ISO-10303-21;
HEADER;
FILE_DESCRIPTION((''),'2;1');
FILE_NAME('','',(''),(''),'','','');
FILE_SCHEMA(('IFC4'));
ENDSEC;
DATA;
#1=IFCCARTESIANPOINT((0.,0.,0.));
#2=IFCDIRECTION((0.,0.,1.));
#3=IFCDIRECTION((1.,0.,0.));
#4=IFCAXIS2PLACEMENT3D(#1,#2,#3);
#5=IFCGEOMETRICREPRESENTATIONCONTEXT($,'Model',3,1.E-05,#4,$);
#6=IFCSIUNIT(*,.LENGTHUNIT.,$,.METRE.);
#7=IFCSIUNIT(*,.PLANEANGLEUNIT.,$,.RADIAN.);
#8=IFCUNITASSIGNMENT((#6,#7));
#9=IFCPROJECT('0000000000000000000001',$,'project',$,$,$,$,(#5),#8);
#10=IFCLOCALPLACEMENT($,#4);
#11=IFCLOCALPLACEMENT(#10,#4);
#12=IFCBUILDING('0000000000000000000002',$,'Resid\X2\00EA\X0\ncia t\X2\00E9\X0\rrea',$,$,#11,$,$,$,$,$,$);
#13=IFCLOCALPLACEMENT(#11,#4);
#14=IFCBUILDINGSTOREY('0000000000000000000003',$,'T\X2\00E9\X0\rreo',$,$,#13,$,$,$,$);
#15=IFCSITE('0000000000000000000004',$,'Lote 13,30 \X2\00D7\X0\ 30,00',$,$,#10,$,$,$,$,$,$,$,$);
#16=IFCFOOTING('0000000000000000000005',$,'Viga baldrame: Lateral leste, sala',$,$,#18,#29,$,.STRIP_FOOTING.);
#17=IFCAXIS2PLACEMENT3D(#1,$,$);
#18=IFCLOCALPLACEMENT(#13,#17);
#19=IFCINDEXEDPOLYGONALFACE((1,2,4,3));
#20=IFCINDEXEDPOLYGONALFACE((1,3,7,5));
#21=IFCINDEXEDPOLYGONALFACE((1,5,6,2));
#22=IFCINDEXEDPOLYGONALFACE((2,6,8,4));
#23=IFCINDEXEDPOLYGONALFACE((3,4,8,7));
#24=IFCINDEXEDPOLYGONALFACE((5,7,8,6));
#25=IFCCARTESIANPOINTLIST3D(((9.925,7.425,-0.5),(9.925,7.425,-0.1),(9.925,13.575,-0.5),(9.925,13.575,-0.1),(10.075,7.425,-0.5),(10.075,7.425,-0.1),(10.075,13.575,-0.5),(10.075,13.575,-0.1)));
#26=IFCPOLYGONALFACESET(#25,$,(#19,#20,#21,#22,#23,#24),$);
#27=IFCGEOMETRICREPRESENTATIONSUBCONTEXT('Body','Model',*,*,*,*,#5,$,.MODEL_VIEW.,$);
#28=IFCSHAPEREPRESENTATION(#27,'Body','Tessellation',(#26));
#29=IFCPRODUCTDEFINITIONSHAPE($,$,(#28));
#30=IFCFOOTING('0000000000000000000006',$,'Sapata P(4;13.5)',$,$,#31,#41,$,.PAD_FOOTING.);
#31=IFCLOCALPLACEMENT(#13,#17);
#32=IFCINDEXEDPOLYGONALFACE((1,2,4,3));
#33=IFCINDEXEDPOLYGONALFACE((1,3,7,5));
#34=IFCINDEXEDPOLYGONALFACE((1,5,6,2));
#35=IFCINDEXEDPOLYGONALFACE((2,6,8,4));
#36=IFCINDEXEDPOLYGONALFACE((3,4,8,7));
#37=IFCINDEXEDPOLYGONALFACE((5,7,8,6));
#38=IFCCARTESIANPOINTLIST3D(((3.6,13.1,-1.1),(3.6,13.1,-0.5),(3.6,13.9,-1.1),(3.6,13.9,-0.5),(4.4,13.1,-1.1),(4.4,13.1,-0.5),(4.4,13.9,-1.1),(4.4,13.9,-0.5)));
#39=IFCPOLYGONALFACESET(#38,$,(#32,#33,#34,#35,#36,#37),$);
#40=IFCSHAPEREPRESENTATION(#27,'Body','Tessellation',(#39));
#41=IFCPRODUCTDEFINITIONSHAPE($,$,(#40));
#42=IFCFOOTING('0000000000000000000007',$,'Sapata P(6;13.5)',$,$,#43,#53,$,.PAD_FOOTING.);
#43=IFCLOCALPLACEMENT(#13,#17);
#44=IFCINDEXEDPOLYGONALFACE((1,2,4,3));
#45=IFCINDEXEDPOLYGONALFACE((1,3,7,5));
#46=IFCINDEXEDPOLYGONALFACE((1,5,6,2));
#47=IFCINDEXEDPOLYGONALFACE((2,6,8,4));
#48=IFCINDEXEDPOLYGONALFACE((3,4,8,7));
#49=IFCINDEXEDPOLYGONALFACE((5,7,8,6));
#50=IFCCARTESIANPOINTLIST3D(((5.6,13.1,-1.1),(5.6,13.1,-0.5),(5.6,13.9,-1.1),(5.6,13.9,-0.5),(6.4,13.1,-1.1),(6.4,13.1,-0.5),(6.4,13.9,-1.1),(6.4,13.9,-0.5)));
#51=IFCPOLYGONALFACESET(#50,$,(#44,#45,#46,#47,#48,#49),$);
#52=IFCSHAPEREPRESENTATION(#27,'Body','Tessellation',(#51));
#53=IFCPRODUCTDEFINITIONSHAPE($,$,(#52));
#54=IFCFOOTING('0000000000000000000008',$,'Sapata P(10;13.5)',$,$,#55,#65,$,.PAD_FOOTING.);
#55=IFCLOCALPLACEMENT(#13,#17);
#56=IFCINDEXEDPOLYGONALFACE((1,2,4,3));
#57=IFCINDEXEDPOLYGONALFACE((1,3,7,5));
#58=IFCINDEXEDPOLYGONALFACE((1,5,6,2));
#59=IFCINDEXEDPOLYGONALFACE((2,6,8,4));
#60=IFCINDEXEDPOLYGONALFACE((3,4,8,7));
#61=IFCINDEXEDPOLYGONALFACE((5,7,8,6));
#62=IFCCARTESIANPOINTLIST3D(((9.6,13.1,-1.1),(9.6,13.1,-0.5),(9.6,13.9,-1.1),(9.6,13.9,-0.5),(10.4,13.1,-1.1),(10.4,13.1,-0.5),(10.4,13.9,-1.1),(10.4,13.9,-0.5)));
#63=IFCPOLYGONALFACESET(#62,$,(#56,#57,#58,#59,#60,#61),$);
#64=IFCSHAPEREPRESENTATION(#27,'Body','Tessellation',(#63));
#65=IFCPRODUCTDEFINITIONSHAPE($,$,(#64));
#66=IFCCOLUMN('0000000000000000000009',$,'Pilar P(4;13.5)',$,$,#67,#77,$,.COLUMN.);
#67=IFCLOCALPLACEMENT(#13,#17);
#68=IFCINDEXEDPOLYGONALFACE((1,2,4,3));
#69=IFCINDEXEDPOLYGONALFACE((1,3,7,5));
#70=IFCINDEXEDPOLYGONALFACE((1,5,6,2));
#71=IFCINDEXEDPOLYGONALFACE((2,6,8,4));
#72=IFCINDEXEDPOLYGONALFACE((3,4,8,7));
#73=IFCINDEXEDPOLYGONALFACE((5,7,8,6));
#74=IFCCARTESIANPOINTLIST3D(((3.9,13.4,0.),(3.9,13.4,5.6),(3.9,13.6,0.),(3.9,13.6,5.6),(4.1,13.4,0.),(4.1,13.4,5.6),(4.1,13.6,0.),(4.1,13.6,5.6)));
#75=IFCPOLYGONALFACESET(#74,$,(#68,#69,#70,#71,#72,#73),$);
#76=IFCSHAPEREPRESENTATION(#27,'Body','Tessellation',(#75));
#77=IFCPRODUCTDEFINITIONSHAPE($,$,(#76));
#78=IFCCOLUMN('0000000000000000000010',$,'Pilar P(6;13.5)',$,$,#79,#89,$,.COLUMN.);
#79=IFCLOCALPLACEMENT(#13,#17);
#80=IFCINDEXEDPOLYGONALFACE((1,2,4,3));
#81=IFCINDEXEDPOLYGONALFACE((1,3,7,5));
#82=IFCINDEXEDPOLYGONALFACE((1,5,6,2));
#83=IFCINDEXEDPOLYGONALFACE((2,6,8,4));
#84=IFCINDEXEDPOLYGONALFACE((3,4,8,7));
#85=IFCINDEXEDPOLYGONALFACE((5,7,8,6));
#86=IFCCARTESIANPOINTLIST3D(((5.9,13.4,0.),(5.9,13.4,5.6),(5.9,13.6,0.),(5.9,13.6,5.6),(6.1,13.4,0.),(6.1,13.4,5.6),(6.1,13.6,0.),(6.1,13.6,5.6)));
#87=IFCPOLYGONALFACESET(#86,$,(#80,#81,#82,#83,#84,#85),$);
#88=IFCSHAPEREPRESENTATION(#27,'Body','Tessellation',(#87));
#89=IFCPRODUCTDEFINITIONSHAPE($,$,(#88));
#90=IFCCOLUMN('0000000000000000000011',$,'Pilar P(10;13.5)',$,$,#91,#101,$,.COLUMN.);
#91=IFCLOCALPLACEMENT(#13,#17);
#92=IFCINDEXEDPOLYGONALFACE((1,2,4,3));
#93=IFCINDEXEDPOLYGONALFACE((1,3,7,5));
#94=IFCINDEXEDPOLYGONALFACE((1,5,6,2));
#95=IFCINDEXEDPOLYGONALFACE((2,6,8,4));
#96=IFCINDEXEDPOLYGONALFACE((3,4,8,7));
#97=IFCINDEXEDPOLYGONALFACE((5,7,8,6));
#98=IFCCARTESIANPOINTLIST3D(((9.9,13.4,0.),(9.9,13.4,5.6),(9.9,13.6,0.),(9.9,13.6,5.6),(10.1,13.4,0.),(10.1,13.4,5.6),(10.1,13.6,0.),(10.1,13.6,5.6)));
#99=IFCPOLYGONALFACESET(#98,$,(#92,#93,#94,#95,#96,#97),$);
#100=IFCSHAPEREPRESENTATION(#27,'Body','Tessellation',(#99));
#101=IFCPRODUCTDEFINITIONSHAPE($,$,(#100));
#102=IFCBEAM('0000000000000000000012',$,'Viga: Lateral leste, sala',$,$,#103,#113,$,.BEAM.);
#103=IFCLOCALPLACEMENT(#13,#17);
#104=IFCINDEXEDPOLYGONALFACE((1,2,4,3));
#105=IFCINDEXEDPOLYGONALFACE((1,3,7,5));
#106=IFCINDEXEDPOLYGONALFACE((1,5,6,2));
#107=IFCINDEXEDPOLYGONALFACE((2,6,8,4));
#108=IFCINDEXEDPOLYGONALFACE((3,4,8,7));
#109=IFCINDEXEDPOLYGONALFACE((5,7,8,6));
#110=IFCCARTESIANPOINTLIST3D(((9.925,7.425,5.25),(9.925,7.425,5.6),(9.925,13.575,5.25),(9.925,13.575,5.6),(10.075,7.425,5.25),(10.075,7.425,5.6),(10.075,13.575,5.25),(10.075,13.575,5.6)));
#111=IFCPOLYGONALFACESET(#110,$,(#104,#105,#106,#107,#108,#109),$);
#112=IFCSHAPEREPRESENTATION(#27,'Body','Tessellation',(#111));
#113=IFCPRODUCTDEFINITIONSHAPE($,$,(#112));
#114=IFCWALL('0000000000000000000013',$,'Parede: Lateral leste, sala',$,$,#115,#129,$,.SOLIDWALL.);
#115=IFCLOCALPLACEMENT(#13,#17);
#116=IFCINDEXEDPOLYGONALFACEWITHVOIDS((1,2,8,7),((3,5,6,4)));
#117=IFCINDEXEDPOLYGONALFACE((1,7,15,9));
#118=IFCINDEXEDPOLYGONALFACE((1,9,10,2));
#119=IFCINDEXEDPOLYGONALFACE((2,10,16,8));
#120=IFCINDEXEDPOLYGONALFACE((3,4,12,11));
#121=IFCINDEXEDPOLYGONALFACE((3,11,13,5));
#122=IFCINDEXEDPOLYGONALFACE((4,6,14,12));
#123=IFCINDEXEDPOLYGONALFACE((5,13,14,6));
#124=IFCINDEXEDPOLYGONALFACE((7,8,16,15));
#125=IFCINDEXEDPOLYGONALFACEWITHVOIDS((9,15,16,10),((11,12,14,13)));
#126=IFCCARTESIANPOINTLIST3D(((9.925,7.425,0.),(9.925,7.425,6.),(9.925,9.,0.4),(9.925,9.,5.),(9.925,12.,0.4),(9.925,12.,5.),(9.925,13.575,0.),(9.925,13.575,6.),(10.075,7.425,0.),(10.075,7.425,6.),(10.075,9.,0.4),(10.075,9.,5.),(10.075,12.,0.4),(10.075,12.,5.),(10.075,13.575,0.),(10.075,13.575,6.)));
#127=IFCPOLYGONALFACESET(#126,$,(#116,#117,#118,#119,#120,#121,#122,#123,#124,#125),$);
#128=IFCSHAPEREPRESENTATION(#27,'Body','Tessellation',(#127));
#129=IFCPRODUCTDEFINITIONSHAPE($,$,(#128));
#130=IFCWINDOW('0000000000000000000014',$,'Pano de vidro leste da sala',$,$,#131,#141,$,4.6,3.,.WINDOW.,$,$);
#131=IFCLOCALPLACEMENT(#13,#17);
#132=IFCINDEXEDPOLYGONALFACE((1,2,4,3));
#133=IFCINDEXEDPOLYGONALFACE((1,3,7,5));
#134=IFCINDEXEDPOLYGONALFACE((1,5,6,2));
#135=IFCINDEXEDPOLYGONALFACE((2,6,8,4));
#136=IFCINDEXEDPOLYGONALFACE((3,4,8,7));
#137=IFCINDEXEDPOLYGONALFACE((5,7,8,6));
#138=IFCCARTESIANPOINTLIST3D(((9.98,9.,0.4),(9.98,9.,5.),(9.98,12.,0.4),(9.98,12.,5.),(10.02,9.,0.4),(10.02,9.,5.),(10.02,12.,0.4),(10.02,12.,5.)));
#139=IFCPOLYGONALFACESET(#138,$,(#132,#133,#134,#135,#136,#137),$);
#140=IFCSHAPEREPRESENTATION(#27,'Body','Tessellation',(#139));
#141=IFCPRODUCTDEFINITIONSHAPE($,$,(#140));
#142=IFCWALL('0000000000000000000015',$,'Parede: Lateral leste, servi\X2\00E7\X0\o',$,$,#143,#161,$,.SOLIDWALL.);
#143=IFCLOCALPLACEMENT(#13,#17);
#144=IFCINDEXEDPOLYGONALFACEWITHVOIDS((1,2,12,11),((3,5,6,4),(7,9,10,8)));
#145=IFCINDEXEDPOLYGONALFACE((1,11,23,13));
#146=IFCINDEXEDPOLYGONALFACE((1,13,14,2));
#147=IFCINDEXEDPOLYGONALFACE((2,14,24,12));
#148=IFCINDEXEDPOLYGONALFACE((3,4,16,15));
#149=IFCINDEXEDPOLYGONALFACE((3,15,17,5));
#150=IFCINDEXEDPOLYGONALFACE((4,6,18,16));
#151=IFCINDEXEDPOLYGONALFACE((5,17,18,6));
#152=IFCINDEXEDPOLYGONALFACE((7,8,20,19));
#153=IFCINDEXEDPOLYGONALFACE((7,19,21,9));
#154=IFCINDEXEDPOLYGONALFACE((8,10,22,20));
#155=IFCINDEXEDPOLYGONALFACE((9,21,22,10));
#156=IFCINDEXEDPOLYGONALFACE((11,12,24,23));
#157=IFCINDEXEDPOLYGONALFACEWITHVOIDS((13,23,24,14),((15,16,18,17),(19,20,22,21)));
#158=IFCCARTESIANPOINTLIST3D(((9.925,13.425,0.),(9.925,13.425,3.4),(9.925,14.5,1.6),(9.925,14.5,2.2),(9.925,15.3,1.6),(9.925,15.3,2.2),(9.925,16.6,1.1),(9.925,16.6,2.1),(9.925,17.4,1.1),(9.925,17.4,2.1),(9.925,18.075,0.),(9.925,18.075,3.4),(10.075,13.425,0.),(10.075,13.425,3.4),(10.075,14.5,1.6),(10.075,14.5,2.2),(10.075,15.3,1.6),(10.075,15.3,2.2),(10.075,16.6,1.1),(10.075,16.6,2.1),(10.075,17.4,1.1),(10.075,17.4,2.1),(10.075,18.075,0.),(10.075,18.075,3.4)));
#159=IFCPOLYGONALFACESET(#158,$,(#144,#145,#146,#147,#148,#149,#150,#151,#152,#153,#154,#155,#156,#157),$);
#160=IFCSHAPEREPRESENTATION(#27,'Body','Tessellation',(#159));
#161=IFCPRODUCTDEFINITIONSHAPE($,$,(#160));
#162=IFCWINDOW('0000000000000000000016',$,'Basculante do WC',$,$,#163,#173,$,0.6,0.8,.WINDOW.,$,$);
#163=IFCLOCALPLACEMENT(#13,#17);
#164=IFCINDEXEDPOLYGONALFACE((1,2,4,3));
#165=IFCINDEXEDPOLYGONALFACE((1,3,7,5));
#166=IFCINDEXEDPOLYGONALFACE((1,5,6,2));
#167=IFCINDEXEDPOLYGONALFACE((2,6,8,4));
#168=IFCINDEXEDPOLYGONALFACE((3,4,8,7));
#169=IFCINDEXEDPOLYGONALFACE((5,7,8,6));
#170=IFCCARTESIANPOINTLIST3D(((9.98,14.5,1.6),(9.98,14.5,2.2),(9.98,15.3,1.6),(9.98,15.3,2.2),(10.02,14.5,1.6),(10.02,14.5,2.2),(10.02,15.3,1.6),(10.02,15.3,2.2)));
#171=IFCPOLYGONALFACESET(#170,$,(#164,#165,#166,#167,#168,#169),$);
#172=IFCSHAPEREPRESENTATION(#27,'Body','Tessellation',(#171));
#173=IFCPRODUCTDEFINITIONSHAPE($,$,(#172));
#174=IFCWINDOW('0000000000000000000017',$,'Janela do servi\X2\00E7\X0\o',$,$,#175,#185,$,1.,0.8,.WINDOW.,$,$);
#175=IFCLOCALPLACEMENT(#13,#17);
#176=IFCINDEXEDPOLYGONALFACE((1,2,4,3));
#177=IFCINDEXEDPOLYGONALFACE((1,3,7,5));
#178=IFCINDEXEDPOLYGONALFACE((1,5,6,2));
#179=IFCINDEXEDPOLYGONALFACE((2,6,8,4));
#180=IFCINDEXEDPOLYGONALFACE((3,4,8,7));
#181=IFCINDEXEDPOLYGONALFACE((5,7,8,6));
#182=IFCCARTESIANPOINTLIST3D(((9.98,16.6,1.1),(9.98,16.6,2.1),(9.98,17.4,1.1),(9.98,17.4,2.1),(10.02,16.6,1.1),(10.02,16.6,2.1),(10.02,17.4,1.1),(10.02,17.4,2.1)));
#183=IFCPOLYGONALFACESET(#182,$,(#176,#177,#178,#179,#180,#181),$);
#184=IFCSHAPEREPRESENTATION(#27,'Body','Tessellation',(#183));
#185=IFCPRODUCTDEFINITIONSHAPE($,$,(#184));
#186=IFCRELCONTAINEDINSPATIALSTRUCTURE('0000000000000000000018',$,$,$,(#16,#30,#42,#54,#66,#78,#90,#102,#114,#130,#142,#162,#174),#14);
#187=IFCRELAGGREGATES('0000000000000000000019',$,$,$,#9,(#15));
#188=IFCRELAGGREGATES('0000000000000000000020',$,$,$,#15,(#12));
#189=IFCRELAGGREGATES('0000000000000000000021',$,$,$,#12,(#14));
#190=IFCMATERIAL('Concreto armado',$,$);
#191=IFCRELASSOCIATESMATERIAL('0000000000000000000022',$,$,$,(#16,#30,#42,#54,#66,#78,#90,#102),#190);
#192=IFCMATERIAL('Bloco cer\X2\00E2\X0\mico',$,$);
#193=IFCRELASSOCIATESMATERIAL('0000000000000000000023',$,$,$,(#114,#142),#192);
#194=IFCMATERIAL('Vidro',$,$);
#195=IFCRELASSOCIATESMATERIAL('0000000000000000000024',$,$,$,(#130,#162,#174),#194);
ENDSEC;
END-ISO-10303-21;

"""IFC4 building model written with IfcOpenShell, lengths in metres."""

from ifc_helpers import new_model, si_unit, frame, origin_with_axes, place, context, subcontext, project, spatial, line, indexed_curve, outline, extrude, material, element, fill, save


model = new_model("IFC4")

# Units and contexts
model_context = context("Model", 3, precision=1e-05, world=origin_with_axes())
body_context = subcontext(model_context, "Body", "Model", "MODEL_VIEW")
ifc_project = project(units=[si_unit("LENGTHUNIT", "METRE"), si_unit("PLANEANGLEUNIT", "RADIAN")], contexts=[model_context])

# Site, building, storey
site_placement = place(None, origin_with_axes())
site = spatial("IfcSite", under=ifc_project, at=site_placement, Name="Lote 13,30 × 30,00")
building_placement = place(site_placement, origin_with_axes())
building = spatial("IfcBuilding", under=site, at=building_placement, Name="Residência térrea")
storey_placement = place(building_placement, origin_with_axes())
storey = spatial("IfcBuildingStorey", under=building, at=storey_placement, Name="Térreo")

# Footings
ifc_material_1 = material(Name="Concreto armado")
footing_1_placement = place(storey_placement, frame((9.925, 7.425, -0.5), z_axis=(0.0, 0.0, 1.0), x_axis=(1.0, 0.0, 0.0)))
element("IfcFooting", 1, at=footing_1_placement, inside=storey, material=ifc_material_1, Name="Viga baldrame: Lateral leste, sala", PredefinedType="STRIP_FOOTING", context=body_context, shape_type="SweptSolid", body=[
    extrude(outline(indexed_curve([(0.0, 0.0), (0.15, 0.0), (0.15, 6.15), (0.0, 6.15)], segments=[line(1, 2, 3, 4, 1)])), origin_with_axes(), (0.0, 0.0, 1.0), 0.4),
])
footing_2_placement = place(storey_placement, frame((3.6, 13.1, -1.1), z_axis=(0.0, 0.0, 1.0), x_axis=(1.0, 0.0, 0.0)))
element("IfcFooting", 2, at=footing_2_placement, inside=storey, material=ifc_material_1, Name="Sapata P(4;13.5)", PredefinedType="PAD_FOOTING", context=body_context, shape_type="SweptSolid", body=[
    extrude(outline(indexed_curve([(0.0, 0.0), (0.8, 0.0), (0.8, 0.8), (0.0, 0.8)], segments=[line(1, 2, 3, 4, 1)])), origin_with_axes(), (0.0, 0.0, 1.0), 0.6),
])
for number, where, z_axis, x_axis, name in (
    (3, (5.6, 13.1, -1.1), (0.0, 0.0, 1.0), (1.0, 0.0, 0.0), "Sapata P(6;13.5)"),
    (4, (9.6, 13.1, -1.1), (0.0, 0.0, 1.0), (1.0, 0.0, 0.0), "Sapata P(10;13.5)"),
):
    element("IfcFooting", number, at=place(storey_placement, frame(where, z_axis=z_axis, x_axis=x_axis)), inside=storey, material=ifc_material_1, Name=name, PredefinedType="PAD_FOOTING", context=body_context, shape_type="SweptSolid", body=[
        extrude(outline(indexed_curve([(0.0, 0.0), (0.8, 0.0), (0.8, 0.8), (0.0, 0.8)], segments=[line(1, 2, 3, 4, 1)])), origin_with_axes(), (0.0, 0.0, 1.0), 0.6),
    ])

# Columns
column_placement = place(storey_placement, frame((3.9, 13.4, 0.0), z_axis=(0.0, 0.0, 1.0), x_axis=(1.0, 0.0, 0.0)))
element("IfcColumn", 5, at=column_placement, inside=storey, material=ifc_material_1, Name="Pilar P(4;13.5)", PredefinedType="COLUMN", context=body_context, shape_type="SweptSolid", body=[
    extrude(outline(indexed_curve([(0.0, 0.0), (0.2, 0.0), (0.2, 0.2), (0.0, 0.2)], segments=[line(1, 2, 3, 4, 1)])), origin_with_axes(), (0.0, 0.0, 1.0), 5.6),
])
for number, where, z_axis, x_axis, name in (
    (6, (5.9, 13.4, 0.0), (0.0, 0.0, 1.0), (1.0, 0.0, 0.0), "Pilar P(6;13.5)"),
    (7, (9.9, 13.4, 0.0), (0.0, 0.0, 1.0), (1.0, 0.0, 0.0), "Pilar P(10;13.5)"),
):
    element("IfcColumn", number, at=place(storey_placement, frame(where, z_axis=z_axis, x_axis=x_axis)), inside=storey, material=ifc_material_1, Name=name, PredefinedType="COLUMN", context=body_context, shape_type="SweptSolid", body=[
        extrude(outline(indexed_curve([(0.0, 0.0), (0.2, 0.0), (0.2, 0.2), (0.0, 0.2)], segments=[line(1, 2, 3, 4, 1)])), origin_with_axes(), (0.0, 0.0, 1.0), 5.6),
    ])

# Beam
beam_placement = place(storey_placement, frame((9.925, 7.425, 5.25), z_axis=(0.0, 0.0, 1.0), x_axis=(1.0, 0.0, 0.0)))
element("IfcBeam", 8, at=beam_placement, inside=storey, material=ifc_material_1, Name="Viga: Lateral leste, sala", PredefinedType="BEAM", context=body_context, shape_type="SweptSolid", body=[
    extrude(outline(indexed_curve([(0.0, 0.0), (0.15, 0.0), (0.15, 6.15), (0.0, 6.15)], segments=[line(1, 2, 3, 4, 1)])), origin_with_axes(), (0.0, 0.0, 1.0), 0.35),
])

# Wall, opening, window
ifc_material_2 = material(Name="Bloco cerâmico")
wall_1_placement = place(storey_placement, frame((9.925, 7.425, 0.0), z_axis=(0.0, 0.0, 1.0), x_axis=(1.0, 0.0, 0.0)))
wall_1 = element("IfcWall", 9, at=wall_1_placement, inside=storey, material=ifc_material_2, Name="Parede: Lateral leste, sala", PredefinedType="SOLIDWALL", context=body_context, shape_type="SweptSolid", body=[
    extrude(outline(indexed_curve([(0.0, 0.0), (0.15, 0.0), (0.15, 6.15), (0.0, 6.15)], segments=[line(1, 2, 3, 4, 1)])), origin_with_axes(), (0.0, 0.0, 1.0), 6.0),
])
opening_1_placement = place(wall_1_placement, frame((-0.05, 1.575, 0.4), z_axis=(0.0, 0.0, 1.0), x_axis=(1.0, 0.0, 0.0)))
opening_1 = element("IfcOpeningElement", 10, at=opening_1_placement, cuts=wall_1, material=ifc_material_1, PredefinedType="OPENING", context=body_context, shape_type="SweptSolid", body=[
    extrude(outline(indexed_curve([(0.0, 0.0), (0.25, 0.0), (0.25, 3.0), (0.0, 3.0)], segments=[line(1, 2, 3, 4, 1)])), origin_with_axes(), (0.0, 0.0, 1.0), 4.6),
])
ifc_material_3 = material(Name="Vidro")
window_1_placement = place(storey_placement, frame((9.98, 9.0, 0.4), z_axis=(0.0, 0.0, 1.0), x_axis=(1.0, 0.0, 0.0)))
window_1 = element("IfcWindow", 11, at=window_1_placement, inside=storey, material=ifc_material_3, Name="Pano de vidro leste da sala", OverallHeight=4.6, OverallWidth=3.0, PredefinedType="WINDOW", context=body_context, shape_type="SweptSolid", body=[
    extrude(outline(indexed_curve([(0.0, 0.0), (0.04, 0.0), (0.04, 3.0), (0.0, 3.0)], segments=[line(1, 2, 3, 4, 1)])), origin_with_axes(), (0.0, 0.0, 1.0), 4.6),
])
fill(opening_1, window_1)

# Wall, openings, windows
wall_2_placement = place(storey_placement, frame((9.925, 13.425, 0.0), z_axis=(0.0, 0.0, 1.0), x_axis=(1.0, 0.0, 0.0)))
wall_2 = element("IfcWall", 12, at=wall_2_placement, inside=storey, material=ifc_material_2, Name="Parede: Lateral leste, serviço", PredefinedType="SOLIDWALL", context=body_context, shape_type="SweptSolid", body=[
    extrude(outline(indexed_curve([(0.0, 0.0), (0.15, 0.0), (0.15, 4.65), (0.0, 4.65)], segments=[line(1, 2, 3, 4, 1)])), origin_with_axes(), (0.0, 0.0, 1.0), 3.4),
])
opening_2_placement = place(wall_2_placement, frame((-0.05, 1.075, 1.6), z_axis=(0.0, 0.0, 1.0), x_axis=(1.0, 0.0, 0.0)))
opening_2 = element("IfcOpeningElement", 13, at=opening_2_placement, cuts=wall_2, material=ifc_material_1, PredefinedType="OPENING", context=body_context, shape_type="SweptSolid", body=[
    extrude(outline(indexed_curve([(0.0, 0.0), (0.25, 0.0), (0.25, 0.8), (0.0, 0.8)], segments=[line(1, 2, 3, 4, 1)])), origin_with_axes(), (0.0, 0.0, 1.0), 0.6),
])
opening_3_placement = place(wall_2_placement, frame((-0.05, 3.175, 1.1), z_axis=(0.0, 0.0, 1.0), x_axis=(1.0, 0.0, 0.0)))
opening_3 = element("IfcOpeningElement", 14, at=opening_3_placement, cuts=wall_2, material=ifc_material_1, PredefinedType="OPENING", context=body_context, shape_type="SweptSolid", body=[
    extrude(outline(indexed_curve([(0.0, 0.0), (0.25, 0.0), (0.25, 0.8), (0.0, 0.8)], segments=[line(1, 2, 3, 4, 1)])), origin_with_axes(), (0.0, 0.0, 1.0), 1.0),
])
window_2_placement = place(storey_placement, frame((9.98, 14.5, 1.6), z_axis=(0.0, 0.0, 1.0), x_axis=(1.0, 0.0, 0.0)))
window_2 = element("IfcWindow", 15, at=window_2_placement, inside=storey, material=ifc_material_3, Name="Basculante do WC", OverallHeight=0.6, OverallWidth=0.8, PredefinedType="WINDOW", context=body_context, shape_type="SweptSolid", body=[
    extrude(outline(indexed_curve([(0.0, 0.0), (0.04, 0.0), (0.04, 0.8), (0.0, 0.8)], segments=[line(1, 2, 3, 4, 1)])), origin_with_axes(), (0.0, 0.0, 1.0), 0.6),
])
fill(opening_2, window_2)
window_3_placement = place(storey_placement, frame((9.98, 16.6, 1.1), z_axis=(0.0, 0.0, 1.0), x_axis=(1.0, 0.0, 0.0)))
window_3 = element("IfcWindow", 16, at=window_3_placement, inside=storey, material=ifc_material_3, Name="Janela do serviço", OverallHeight=1.0, OverallWidth=0.8, PredefinedType="WINDOW", context=body_context, shape_type="SweptSolid", body=[
    extrude(outline(indexed_curve([(0.0, 0.0), (0.04, 0.0), (0.04, 0.8), (0.0, 0.8)], segments=[line(1, 2, 3, 4, 1)])), origin_with_axes(), (0.0, 0.0, 1.0), 1.0),
])
fill(opening_3, window_3)

save(model, "model.ifc")
